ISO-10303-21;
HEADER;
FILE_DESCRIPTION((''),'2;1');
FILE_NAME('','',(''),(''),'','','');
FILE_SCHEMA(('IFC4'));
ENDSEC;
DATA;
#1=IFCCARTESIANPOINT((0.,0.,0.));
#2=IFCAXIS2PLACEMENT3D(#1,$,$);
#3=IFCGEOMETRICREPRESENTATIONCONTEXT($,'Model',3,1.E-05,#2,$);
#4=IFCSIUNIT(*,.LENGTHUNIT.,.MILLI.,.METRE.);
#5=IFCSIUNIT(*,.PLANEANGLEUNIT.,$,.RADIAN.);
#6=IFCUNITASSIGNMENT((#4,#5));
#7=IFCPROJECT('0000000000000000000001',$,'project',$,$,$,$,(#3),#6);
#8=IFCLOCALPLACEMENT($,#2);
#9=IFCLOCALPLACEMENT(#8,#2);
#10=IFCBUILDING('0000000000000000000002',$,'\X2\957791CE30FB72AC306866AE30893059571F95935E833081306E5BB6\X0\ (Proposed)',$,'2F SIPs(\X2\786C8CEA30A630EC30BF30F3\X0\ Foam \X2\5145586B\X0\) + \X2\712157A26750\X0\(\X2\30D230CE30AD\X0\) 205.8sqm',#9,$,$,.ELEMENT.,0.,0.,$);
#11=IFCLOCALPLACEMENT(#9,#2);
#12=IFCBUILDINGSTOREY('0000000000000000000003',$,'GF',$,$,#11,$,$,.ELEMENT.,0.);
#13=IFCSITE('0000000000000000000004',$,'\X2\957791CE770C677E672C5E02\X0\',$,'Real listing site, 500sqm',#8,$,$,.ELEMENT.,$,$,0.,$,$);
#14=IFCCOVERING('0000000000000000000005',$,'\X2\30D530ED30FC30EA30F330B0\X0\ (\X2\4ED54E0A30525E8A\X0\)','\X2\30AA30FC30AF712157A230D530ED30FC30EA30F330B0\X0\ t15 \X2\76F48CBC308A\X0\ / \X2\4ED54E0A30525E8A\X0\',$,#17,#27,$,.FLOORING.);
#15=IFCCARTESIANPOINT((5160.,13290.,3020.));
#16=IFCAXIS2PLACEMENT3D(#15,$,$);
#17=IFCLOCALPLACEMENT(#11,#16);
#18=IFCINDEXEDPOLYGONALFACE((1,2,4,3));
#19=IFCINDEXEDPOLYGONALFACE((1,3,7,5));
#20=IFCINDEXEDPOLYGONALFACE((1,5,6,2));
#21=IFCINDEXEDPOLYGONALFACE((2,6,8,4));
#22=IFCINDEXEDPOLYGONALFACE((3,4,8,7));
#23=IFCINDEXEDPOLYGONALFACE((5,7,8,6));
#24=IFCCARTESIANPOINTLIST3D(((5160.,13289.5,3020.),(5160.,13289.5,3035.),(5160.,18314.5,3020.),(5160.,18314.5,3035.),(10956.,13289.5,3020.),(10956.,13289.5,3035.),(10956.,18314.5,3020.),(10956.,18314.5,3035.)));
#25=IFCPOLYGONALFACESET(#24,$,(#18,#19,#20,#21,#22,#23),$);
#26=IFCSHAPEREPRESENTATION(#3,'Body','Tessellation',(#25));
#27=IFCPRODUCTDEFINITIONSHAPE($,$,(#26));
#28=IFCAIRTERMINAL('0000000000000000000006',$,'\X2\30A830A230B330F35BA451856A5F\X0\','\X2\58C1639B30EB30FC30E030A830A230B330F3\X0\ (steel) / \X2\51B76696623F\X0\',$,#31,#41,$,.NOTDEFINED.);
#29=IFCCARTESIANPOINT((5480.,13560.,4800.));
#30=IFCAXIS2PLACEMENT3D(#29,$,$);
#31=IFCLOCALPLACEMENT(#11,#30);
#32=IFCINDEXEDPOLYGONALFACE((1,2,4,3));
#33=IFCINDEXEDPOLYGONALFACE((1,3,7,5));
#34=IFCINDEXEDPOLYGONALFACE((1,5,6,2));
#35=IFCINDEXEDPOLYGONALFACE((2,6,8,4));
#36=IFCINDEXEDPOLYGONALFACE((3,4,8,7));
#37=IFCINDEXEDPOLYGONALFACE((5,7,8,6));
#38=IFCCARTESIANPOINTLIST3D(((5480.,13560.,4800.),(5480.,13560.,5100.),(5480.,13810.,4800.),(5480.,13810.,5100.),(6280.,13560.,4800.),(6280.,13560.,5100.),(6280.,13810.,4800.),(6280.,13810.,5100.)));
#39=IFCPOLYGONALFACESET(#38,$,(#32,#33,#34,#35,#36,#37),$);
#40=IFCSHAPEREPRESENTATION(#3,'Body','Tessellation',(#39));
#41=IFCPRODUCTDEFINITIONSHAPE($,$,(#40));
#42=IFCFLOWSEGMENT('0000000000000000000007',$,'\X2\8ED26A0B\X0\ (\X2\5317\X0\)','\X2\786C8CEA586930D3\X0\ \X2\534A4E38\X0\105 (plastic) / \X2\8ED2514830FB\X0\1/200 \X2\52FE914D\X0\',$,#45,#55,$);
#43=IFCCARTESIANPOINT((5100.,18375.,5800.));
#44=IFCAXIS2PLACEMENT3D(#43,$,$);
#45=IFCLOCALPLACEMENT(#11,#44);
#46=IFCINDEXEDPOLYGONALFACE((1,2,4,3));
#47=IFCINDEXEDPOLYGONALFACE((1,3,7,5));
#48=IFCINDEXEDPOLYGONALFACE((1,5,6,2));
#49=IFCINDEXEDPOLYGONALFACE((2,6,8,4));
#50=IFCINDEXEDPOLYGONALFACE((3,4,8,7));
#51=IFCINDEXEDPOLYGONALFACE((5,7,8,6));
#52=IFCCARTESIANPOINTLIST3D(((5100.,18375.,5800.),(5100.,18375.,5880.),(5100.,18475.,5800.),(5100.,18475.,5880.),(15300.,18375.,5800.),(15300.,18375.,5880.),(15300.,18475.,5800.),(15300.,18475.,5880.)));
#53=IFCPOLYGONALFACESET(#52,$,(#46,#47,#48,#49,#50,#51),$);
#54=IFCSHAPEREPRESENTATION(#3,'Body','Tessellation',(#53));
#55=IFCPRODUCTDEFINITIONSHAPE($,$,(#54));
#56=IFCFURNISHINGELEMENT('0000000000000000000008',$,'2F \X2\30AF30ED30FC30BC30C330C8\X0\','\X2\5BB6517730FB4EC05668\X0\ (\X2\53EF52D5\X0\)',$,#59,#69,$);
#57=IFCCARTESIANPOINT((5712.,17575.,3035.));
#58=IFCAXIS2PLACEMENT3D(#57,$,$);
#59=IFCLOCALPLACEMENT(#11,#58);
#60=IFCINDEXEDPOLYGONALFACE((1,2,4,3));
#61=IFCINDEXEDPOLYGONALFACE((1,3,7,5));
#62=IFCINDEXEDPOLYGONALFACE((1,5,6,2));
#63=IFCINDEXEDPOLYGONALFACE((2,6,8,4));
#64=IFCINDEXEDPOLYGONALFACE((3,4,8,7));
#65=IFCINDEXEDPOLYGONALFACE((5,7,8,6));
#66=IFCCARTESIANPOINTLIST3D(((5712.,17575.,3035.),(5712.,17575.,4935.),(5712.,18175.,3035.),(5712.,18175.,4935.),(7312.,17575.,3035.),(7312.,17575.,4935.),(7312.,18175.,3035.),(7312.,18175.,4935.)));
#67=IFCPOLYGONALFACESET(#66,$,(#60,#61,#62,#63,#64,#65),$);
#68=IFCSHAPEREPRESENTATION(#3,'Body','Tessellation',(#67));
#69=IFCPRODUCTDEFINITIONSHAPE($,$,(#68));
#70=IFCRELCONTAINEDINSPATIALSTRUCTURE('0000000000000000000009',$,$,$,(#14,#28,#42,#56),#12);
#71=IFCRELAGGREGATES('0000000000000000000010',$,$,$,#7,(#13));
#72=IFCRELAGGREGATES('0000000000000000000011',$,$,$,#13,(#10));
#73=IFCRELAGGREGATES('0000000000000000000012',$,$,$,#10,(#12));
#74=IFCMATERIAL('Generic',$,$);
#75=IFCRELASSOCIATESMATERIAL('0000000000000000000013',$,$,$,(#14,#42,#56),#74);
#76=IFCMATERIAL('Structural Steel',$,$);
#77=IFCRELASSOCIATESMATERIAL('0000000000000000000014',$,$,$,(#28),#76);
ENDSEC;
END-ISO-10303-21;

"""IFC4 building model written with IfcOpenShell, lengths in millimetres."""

from ifc_helpers import new_model, si_unit, frame, frame_2d, origin, place, context, project, spatial, rectangle, extrude, material, element, save


model = new_model("IFC4")

# Units and contexts
model_context = context("Model", 3, precision=1e-05, world=origin())
ifc_project = project(units=[si_unit("LENGTHUNIT", "METRE", prefix="MILLI"), si_unit("PLANEANGLEUNIT", "RADIAN")], contexts=[model_context])

# Site, building, storey
site_placement = place(None, origin())
site = spatial("IfcSite", under=ifc_project, at=site_placement, Name="長野県松本市", ObjectType="Real listing site, 500sqm", CompositionType="ELEMENT", RefElevation=0.0)
building_placement = place(site_placement, origin())
building = spatial("IfcBuilding", under=site, at=building_placement, Name="長野・犬と暮らす土間広めの家 (Proposed)", ObjectType="2F SIPs(硬質ウレタン Foam 充填) + 無垢材(ヒノキ) 205.8sqm", CompositionType="ELEMENT", ElevationOfRefHeight=0.0, ElevationOfTerrain=0.0)
storey_placement = place(building_placement, origin())
storey = spatial("IfcBuildingStorey", under=building, at=storey_placement, Name="GF", CompositionType="ELEMENT", Elevation=0.0)

# Shared definitions
ifc_material_1 = material(Name="Structural Steel")

# Covering
ifc_material_2 = material(Name="Generic")
covering_placement = place(storey_placement, frame((5160.0, 13290.0, 3020.0)))
element("IfcCovering", 1, at=covering_placement, inside=storey, material=ifc_material_2, Name="フローリング (仕上げ床)", Description="オーク無垢フローリング t15 直貼り / 仕上げ床", PredefinedType="FLOORING", context=model_context, shape_type="SweptSolid", body=[
    extrude(rectangle(XDim=5796.0, YDim=5025.0, at=frame_2d((2898.0, 2512.0))), frame((5160.0, 13290.0, 3020.0)), (0.0, 0.0, 1.0), 15.0),
])

# Air terminal
air_terminal_placement = place(storey_placement, frame((5480.0, 13560.0, 4800.0)))
element("IfcAirTerminal", 2, at=air_terminal_placement, inside=storey, material=ifc_material_1, Name="エアコン室内機", Description="壁掛ルームエアコン (steel) / 冷暖房", PredefinedType="NOTDEFINED", context=model_context, shape_type="SweptSolid", body=[
    extrude(rectangle(XDim=800.0, YDim=250.0, at=frame_2d((400.0, 125.0))), frame((5480.0, 13560.0, 4800.0)), (0.0, 0.0, 1.0), 300.0),
])

# Flow segment
flow_segment_placement = place(storey_placement, frame((5100.0, 18375.0, 5800.0)))
element("IfcFlowSegment", 3, at=flow_segment_placement, inside=storey, material=ifc_material_2, Name="軒樋 (北)", Description="硬質塩ビ 半丸105 (plastic) / 軒先・1/200 勾配", context=model_context, shape_type="SweptSolid", body=[
    extrude(rectangle(XDim=10200.0, YDim=100.0, at=frame_2d((5100.0, 50.0))), frame((5100.0, 18375.0, 5800.0)), (0.0, 0.0, 1.0), 80.0),
])

# Furnishing element
furnishing_placement = place(storey_placement, frame((5712.0, 17575.0, 3035.0)))
element("IfcFurnishingElement", 4, at=furnishing_placement, inside=storey, material=ifc_material_2, Name="2F クローゼット", Description="家具・什器 (可動)", context=model_context, shape_type="SweptSolid", body=[
    extrude(rectangle(XDim=1600.0, YDim=600.0, at=frame_2d((800.0, 300.0))), frame((5712.0, 17575.0, 3035.0)), (0.0, 0.0, 1.0), 1900.0),
])

save(model, "model.ifc")
